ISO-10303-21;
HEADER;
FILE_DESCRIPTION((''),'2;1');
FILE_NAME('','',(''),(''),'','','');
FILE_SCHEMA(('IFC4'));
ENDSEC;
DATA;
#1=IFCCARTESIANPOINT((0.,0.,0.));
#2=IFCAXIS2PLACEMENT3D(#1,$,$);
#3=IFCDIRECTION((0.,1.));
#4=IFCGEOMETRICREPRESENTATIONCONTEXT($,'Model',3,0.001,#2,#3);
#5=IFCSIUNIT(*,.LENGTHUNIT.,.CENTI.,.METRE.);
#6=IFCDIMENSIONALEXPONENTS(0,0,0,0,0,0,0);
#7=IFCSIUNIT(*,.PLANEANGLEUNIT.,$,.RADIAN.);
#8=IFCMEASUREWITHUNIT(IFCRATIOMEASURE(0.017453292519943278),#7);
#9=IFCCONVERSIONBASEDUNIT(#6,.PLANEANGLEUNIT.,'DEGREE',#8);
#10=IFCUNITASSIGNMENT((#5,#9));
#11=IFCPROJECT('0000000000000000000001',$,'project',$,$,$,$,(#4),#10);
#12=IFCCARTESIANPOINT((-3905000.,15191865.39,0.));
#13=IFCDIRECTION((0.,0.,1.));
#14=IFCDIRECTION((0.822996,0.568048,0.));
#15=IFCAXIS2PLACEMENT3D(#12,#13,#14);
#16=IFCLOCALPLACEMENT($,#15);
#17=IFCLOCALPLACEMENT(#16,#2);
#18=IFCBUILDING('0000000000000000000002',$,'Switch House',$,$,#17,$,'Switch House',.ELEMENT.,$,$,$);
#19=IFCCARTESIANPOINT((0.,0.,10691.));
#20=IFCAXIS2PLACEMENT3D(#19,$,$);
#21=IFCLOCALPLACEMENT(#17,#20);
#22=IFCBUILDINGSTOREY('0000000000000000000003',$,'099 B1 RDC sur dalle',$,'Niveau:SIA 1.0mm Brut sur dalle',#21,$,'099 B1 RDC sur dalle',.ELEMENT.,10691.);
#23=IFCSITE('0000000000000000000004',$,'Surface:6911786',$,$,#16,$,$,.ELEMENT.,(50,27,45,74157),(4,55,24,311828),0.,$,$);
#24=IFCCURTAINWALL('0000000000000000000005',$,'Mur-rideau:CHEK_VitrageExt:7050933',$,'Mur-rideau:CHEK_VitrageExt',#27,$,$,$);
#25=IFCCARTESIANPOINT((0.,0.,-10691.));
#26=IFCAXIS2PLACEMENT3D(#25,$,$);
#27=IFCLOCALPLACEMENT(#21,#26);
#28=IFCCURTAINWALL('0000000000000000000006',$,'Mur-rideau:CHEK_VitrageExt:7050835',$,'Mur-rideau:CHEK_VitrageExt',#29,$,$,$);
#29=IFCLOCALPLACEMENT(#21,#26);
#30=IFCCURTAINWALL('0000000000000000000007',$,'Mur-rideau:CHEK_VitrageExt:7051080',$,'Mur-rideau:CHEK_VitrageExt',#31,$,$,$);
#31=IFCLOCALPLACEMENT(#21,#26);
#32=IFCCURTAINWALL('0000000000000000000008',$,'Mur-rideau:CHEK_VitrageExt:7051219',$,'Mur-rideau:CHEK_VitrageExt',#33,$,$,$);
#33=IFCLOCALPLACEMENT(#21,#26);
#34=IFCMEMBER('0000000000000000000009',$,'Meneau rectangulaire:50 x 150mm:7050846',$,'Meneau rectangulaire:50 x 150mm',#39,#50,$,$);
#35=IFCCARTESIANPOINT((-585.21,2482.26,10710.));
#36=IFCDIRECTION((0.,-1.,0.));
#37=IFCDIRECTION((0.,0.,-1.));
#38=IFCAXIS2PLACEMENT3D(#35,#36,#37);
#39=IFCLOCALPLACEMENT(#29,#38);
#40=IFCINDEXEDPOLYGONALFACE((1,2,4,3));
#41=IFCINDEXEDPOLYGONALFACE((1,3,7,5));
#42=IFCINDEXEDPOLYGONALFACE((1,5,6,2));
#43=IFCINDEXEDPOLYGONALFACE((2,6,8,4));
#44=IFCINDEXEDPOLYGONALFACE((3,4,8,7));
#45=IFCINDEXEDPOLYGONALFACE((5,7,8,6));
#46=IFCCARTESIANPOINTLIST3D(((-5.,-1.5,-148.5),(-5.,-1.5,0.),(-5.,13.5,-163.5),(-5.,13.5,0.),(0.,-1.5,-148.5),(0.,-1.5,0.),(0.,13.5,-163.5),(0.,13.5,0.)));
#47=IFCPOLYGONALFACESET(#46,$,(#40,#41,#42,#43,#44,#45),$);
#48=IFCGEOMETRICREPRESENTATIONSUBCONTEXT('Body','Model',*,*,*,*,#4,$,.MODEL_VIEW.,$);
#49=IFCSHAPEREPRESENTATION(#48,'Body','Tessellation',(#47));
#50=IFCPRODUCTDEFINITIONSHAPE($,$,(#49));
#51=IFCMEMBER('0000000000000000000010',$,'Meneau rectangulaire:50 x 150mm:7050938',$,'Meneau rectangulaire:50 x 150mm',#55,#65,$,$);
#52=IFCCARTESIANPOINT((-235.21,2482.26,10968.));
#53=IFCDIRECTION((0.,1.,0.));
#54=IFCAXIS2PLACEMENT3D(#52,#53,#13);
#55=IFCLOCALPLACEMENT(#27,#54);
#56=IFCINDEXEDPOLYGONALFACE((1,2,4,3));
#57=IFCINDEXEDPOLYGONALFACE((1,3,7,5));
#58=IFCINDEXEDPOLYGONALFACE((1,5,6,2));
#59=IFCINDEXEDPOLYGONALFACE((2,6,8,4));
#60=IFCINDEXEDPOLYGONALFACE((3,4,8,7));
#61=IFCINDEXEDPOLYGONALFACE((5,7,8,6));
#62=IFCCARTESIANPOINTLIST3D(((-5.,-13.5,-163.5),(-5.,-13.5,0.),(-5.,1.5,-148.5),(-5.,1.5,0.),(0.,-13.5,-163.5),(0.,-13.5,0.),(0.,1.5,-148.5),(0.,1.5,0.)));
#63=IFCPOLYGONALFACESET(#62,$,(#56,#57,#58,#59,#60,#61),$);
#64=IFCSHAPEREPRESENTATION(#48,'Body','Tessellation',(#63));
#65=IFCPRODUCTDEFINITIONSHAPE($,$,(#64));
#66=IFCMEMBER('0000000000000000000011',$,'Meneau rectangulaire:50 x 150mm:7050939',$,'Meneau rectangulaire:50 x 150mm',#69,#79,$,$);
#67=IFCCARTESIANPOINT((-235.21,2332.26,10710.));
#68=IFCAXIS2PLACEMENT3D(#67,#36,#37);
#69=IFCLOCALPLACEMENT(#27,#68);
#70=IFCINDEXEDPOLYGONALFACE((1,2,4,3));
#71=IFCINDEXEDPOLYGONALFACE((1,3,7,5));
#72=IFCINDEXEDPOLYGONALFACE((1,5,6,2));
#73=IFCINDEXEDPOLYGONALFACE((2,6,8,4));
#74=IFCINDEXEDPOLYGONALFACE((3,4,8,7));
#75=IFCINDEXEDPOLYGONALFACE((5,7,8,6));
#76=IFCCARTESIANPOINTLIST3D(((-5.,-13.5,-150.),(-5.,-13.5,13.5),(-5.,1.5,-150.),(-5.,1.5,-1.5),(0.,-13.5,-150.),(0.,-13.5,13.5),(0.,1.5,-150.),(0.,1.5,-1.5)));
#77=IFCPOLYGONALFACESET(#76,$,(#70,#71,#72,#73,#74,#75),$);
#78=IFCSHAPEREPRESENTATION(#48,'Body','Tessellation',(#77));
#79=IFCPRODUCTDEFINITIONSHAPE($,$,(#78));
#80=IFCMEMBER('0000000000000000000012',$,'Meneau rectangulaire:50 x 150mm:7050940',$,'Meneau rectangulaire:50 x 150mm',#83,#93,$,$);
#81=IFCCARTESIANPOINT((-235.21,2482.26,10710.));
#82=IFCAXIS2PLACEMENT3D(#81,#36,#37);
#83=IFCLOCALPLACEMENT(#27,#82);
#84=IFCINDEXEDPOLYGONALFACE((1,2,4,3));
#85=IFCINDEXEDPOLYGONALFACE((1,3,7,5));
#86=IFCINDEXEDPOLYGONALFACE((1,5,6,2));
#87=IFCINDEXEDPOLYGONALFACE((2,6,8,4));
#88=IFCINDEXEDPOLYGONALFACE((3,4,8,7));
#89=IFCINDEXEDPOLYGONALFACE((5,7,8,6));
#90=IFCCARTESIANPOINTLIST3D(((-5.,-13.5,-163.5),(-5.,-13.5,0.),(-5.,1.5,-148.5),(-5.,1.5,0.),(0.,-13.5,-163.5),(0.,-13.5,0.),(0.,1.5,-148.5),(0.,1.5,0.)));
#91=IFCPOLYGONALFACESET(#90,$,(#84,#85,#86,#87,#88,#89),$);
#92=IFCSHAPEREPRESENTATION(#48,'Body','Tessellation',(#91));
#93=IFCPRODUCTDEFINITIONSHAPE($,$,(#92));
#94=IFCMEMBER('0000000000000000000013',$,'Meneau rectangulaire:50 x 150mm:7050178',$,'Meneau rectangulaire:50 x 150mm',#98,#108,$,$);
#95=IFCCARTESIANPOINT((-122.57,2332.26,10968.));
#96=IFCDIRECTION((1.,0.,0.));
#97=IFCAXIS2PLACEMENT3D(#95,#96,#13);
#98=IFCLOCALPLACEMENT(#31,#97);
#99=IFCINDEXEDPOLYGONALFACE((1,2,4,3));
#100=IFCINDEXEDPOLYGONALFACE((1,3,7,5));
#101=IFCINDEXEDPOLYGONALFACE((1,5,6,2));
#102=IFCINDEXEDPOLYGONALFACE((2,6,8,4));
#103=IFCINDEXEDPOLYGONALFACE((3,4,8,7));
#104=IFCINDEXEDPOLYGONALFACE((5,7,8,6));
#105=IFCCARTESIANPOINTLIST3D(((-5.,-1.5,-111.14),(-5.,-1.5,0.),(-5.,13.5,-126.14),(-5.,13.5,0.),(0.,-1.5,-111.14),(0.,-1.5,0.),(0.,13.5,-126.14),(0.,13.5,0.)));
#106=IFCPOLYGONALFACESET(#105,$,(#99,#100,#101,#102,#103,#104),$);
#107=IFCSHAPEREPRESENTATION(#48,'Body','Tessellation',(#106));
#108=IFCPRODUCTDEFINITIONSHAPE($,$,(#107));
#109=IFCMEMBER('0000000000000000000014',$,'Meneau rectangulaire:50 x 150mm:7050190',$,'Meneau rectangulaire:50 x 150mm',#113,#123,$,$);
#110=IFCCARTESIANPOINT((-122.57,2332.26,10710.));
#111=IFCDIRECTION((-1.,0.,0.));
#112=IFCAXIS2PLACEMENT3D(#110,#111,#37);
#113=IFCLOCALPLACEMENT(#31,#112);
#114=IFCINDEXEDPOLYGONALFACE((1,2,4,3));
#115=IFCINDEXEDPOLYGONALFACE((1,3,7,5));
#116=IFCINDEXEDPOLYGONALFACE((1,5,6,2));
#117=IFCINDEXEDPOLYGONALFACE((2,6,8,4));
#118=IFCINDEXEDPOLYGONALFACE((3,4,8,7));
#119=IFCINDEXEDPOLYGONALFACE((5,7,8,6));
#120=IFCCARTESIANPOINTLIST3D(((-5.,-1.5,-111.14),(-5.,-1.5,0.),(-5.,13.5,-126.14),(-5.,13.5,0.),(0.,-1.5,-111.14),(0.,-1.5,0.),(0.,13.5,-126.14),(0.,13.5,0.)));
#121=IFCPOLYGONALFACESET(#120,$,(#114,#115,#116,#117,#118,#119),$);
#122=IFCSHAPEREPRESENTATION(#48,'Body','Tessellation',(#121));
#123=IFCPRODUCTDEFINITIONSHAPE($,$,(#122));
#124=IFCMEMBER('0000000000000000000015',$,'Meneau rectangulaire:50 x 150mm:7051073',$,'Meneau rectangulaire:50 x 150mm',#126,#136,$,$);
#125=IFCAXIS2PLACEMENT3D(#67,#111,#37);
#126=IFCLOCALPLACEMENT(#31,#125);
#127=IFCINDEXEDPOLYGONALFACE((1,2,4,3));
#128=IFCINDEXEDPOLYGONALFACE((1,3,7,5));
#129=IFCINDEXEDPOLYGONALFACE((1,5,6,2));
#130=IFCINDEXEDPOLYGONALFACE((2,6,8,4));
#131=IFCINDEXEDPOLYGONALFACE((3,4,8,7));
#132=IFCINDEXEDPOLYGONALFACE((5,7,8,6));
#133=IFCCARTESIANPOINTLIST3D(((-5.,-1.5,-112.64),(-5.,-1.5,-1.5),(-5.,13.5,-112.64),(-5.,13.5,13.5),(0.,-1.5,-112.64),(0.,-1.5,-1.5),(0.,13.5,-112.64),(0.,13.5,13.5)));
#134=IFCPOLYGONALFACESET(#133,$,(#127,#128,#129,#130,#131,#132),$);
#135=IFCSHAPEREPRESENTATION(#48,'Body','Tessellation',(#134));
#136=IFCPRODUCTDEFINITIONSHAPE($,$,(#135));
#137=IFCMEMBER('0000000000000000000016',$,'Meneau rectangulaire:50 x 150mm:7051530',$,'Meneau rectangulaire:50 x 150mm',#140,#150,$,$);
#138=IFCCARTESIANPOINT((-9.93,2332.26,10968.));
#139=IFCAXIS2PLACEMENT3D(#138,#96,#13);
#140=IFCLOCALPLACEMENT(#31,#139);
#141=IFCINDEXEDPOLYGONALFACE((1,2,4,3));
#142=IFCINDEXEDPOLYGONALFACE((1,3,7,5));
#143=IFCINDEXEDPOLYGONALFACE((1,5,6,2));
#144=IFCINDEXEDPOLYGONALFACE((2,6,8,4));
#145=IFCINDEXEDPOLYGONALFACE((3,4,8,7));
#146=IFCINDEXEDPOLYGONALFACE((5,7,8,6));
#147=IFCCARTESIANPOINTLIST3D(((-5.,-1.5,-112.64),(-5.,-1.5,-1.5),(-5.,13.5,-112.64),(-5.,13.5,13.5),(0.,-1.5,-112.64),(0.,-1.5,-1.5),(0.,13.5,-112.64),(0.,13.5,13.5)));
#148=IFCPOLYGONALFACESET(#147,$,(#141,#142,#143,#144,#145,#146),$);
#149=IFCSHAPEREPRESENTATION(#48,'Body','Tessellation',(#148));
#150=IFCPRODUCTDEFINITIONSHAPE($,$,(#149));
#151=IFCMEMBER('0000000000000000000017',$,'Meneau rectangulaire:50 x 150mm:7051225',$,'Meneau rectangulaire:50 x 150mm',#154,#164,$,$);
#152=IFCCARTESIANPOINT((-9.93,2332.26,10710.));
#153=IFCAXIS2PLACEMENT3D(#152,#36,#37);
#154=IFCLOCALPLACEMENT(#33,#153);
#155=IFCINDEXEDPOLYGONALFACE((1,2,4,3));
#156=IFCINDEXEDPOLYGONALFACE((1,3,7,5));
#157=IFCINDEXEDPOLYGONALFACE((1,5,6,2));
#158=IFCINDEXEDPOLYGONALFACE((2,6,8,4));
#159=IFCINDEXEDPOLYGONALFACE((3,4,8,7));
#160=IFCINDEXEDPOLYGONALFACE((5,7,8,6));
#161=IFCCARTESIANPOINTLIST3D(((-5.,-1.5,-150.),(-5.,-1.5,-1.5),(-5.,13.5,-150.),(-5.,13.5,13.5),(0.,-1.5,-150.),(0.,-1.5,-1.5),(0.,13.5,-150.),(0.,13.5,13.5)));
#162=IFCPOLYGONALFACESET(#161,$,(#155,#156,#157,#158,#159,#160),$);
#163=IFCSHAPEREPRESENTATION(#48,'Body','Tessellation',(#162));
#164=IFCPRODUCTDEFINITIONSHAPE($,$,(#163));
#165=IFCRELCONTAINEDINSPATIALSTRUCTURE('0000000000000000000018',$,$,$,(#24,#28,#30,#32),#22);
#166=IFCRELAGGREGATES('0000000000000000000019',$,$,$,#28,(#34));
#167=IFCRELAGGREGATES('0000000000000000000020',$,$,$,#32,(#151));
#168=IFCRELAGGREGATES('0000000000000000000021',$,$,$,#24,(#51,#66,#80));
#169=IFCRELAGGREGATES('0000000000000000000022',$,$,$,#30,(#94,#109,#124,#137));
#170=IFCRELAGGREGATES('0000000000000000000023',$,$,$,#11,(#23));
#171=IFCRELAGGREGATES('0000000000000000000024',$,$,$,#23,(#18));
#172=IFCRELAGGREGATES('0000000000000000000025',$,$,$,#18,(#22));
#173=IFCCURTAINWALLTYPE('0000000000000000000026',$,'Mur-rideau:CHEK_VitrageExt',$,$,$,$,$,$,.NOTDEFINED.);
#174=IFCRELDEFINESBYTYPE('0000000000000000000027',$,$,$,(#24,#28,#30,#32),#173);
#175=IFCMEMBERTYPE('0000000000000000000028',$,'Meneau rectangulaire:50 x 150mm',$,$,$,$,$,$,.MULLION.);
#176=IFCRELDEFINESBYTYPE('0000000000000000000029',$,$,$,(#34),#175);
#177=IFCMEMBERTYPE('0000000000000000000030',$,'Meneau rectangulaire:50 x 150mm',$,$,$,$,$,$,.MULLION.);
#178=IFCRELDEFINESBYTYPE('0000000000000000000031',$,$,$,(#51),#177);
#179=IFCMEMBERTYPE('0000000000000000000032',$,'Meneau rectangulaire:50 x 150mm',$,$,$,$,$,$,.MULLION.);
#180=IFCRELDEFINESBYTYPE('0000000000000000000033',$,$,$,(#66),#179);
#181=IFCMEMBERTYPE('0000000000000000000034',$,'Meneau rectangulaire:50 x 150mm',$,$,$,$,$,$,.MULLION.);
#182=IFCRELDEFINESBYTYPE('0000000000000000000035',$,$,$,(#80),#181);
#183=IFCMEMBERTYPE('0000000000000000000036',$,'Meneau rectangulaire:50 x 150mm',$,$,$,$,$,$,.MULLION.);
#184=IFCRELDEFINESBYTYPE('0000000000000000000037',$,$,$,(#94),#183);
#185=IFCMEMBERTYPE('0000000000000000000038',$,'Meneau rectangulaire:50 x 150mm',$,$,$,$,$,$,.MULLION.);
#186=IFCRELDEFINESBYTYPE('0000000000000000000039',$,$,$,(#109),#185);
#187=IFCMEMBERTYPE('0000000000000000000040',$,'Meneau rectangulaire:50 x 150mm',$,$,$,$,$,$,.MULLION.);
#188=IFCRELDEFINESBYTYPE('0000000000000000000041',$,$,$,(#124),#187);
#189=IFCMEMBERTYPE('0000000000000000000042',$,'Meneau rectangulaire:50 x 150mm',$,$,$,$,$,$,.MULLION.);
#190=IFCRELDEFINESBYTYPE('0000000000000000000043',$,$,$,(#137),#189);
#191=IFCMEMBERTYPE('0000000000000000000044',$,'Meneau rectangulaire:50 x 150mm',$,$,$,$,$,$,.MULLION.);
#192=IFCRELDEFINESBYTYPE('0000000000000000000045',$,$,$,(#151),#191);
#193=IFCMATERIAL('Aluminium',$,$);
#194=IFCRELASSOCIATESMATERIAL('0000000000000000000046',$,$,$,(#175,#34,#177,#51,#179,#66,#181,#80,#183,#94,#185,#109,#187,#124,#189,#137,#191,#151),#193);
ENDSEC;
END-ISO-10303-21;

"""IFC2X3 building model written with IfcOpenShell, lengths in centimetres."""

from ifc_helpers import new_model, entity, si_unit, converted_unit, direction, frame, origin, origin_2d_with_axis, place, context, subcontext, project, spatial, rectangle, extrude, clip, halfspace, source, transform, mapped, material, type_object, type_shapes, element, aggregate, save


model = new_model("IFC2X3")

# Units and contexts
model_context = context("Model", 3, precision=0.001, world=origin(), true_north=direction((0.0, 1.0)))
body_context = subcontext(model_context, "Body", "Model", "MODEL_VIEW")
ifc_project = project(units=[si_unit("LENGTHUNIT", "METRE", prefix="CENTI"), converted_unit("PLANEANGLEUNIT", "DEGREE", entity("IfcRatioMeasure", 0.017453292519943278), si_unit("PLANEANGLEUNIT", "RADIAN"), dimensions=[0, 0, 0, 0, 0, 0, 0])], contexts=[model_context])

# Site, building, storey
site_placement = place(None, frame((-3905000.0, 15191865.39, 0.0), z_axis=(0.0, 0.0, 1.0), x_axis=(0.822996, 0.568048, 0.0)))
site = spatial("IfcSite", under=ifc_project, at=site_placement, Name="Surface:6911786", CompositionType="ELEMENT", RefLatitude=(50, 27, 45, 74157), RefLongitude=(4, 55, 24, 311828), RefElevation=0.0)
building_placement = place(site_placement, origin())
building = spatial("IfcBuilding", under=site, at=building_placement, Name="Switch House", LongName="Switch House", CompositionType="ELEMENT")
storey_placement = place(building_placement, frame((0.0, 0.0, 10691.0)))
storey = spatial("IfcBuildingStorey", under=building, at=storey_placement, Name="099 B1 RDC sur dalle", ObjectType="Niveau:SIA 1.0mm Brut sur dalle", LongName="099 B1 RDC sur dalle", CompositionType="ELEMENT", Elevation=10691.0)

# Curtain wall
curtain_wall_type = type_object("IfcCurtainWallType", Name="Mur-rideau:CHEK_VitrageExt", PredefinedType="NOTDEFINED")
curtain_wall_1_placement = place(storey_placement, frame((0.0, 0.0, -10691.0)))
curtain_wall_1 = element("IfcCurtainWall", 1, at=curtain_wall_1_placement, inside=storey, type_object=curtain_wall_type, Name="Mur-rideau:CHEK_VitrageExt:7050933", ObjectType="Mur-rideau:CHEK_VitrageExt")
ifc_material_1 = material(Name="Aluminium")

# Curtain walls
curtain_wall_2_placement = place(storey_placement, frame((0.0, 0.0, -10691.0)))
curtain_wall_2 = element("IfcCurtainWall", 2, at=curtain_wall_2_placement, inside=storey, type_object=curtain_wall_type, Name="Mur-rideau:CHEK_VitrageExt:7050835", ObjectType="Mur-rideau:CHEK_VitrageExt")
curtain_wall_3_placement = place(storey_placement, frame((0.0, 0.0, -10691.0)))
curtain_wall_3 = element("IfcCurtainWall", 3, at=curtain_wall_3_placement, inside=storey, type_object=curtain_wall_type, Name="Mur-rideau:CHEK_VitrageExt:7051080", ObjectType="Mur-rideau:CHEK_VitrageExt")
curtain_wall_4_placement = place(storey_placement, frame((0.0, 0.0, -10691.0)))
curtain_wall_4 = element("IfcCurtainWall", 4, at=curtain_wall_4_placement, inside=storey, type_object=curtain_wall_type, Name="Mur-rideau:CHEK_VitrageExt:7051219", ObjectType="Mur-rideau:CHEK_VitrageExt")

# Members
member_type_1 = type_object("IfcMemberType", Name="Meneau rectangulaire:50 x 150mm", PredefinedType="MULLION", material=ifc_material_1)
shared_shape_1 = source(origin(), body_context, "Body", "SweptSolid", [
    clip(extrude(rectangle(XDim=15.0, YDim=5.0, at=origin_2d_with_axis()), frame((-2.5, 6.0, -163.5), z_axis=(0.0, 0.0, 1.0), x_axis=(0.0, -1.0, 0.0)), (0.0, 0.0, 1.0), 163.5), halfspace(frame((30.48, 0.0, -150.0), z_axis=(0.0, -0.707107, -0.707107), x_axis=(0.0, -0.707107, 0.707107)), False)),
])
type_shapes(member_type_1, [shared_shape_1])
member_1_placement = place(curtain_wall_2_placement, frame((-585.21, 2482.26, 10710.0), z_axis=(0.0, -1.0, 0.0), x_axis=(0.0, 0.0, -1.0)))
member_1 = element("IfcMember", 5, at=member_1_placement, type_object=member_type_1, material=ifc_material_1, Name="Meneau rectangulaire:50 x 150mm:7050846", ObjectType="Meneau rectangulaire:50 x 150mm", context=body_context, shape_type="MappedRepresentation", body=[
    mapped(shared_shape_1, transform((0.0, 0.0, 0.0), scale=1.0)),
])
member_type_2 = type_object("IfcMemberType", Name="Meneau rectangulaire:50 x 150mm", PredefinedType="MULLION", material=ifc_material_1)
shared_shape_2 = source(origin(), body_context, "Body", "SweptSolid", [
    clip(extrude(rectangle(XDim=15.0, YDim=5.0, at=origin_2d_with_axis()), frame((-2.5, -6.0, -163.5), z_axis=(0.0, 0.0, 1.0), x_axis=(0.0, -1.0, 0.0)), (0.0, 0.0, 1.0), 163.5), halfspace(frame((-30.48, 0.0, -150.0), z_axis=(0.0, 0.707107, -0.707107), x_axis=(0.0, 0.707107, 0.707107)), False)),
])
type_shapes(member_type_2, [shared_shape_2])
member_2_placement = place(curtain_wall_1_placement, frame((-235.21, 2482.26, 10968.0), z_axis=(0.0, 1.0, 0.0), x_axis=(0.0, 0.0, 1.0)))
member_2 = element("IfcMember", 6, at=member_2_placement, type_object=member_type_2, material=ifc_material_1, Name="Meneau rectangulaire:50 x 150mm:7050938", ObjectType="Meneau rectangulaire:50 x 150mm", context=body_context, shape_type="MappedRepresentation", body=[
    mapped(shared_shape_2, transform((0.0, 0.0, 0.0), scale=1.0)),
])
member_type_3 = type_object("IfcMemberType", Name="Meneau rectangulaire:50 x 150mm", PredefinedType="MULLION", material=ifc_material_1)
shared_shape_3 = source(origin(), body_context, "Body", "SweptSolid", [
    clip(extrude(rectangle(XDim=15.0, YDim=5.0, at=origin_2d_with_axis()), frame((-2.5, -6.0, -150.0), z_axis=(0.0, 0.0, 1.0), x_axis=(0.0, -1.0, 0.0)), (0.0, 0.0, 1.0), 163.5), halfspace(frame((-30.48, 0.0, 0.0), z_axis=(0.0, 0.707107, 0.707107), x_axis=(0.0, 0.707107, -0.707107)), False)),
])
type_shapes(member_type_3, [shared_shape_3])
member_3_placement = place(curtain_wall_1_placement, frame((-235.21, 2332.26, 10710.0), z_axis=(0.0, -1.0, 0.0), x_axis=(0.0, 0.0, -1.0)))
member_3 = element("IfcMember", 7, at=member_3_placement, type_object=member_type_3, material=ifc_material_1, Name="Meneau rectangulaire:50 x 150mm:7050939", ObjectType="Meneau rectangulaire:50 x 150mm", context=body_context, shape_type="MappedRepresentation", body=[
    mapped(shared_shape_3, transform((0.0, 0.0, 0.0), scale=1.0)),
])
member_type_4 = type_object("IfcMemberType", Name="Meneau rectangulaire:50 x 150mm", PredefinedType="MULLION", material=ifc_material_1)
shared_shape_4 = source(origin(), body_context, "Body", "SweptSolid", [
    clip(extrude(rectangle(XDim=15.0, YDim=5.0, at=origin_2d_with_axis()), frame((-2.5, -6.0, -163.5), z_axis=(0.0, 0.0, 1.0), x_axis=(0.0, -1.0, 0.0)), (0.0, 0.0, 1.0), 163.5), halfspace(frame((-30.48, 0.0, -150.0), z_axis=(0.0, 0.707107, -0.707107), x_axis=(0.0, 0.707107, 0.707107)), False)),
])
type_shapes(member_type_4, [shared_shape_4])
member_4_placement = place(curtain_wall_1_placement, frame((-235.21, 2482.26, 10710.0), z_axis=(0.0, -1.0, 0.0), x_axis=(0.0, 0.0, -1.0)))
member_4 = element("IfcMember", 8, at=member_4_placement, type_object=member_type_4, material=ifc_material_1, Name="Meneau rectangulaire:50 x 150mm:7050940", ObjectType="Meneau rectangulaire:50 x 150mm", context=body_context, shape_type="MappedRepresentation", body=[
    mapped(shared_shape_4, transform((0.0, 0.0, 0.0), scale=1.0)),
])
member_type_5 = type_object("IfcMemberType", Name="Meneau rectangulaire:50 x 150mm", PredefinedType="MULLION", material=ifc_material_1)
shared_shape_5 = source(origin(), body_context, "Body", "SweptSolid", [
    clip(extrude(rectangle(XDim=15.0, YDim=5.0, at=origin_2d_with_axis()), frame((-2.5, 6.0, -126.14), z_axis=(0.0, 0.0, 1.0), x_axis=(0.0, -1.0, 0.0)), (0.0, 0.0, 1.0), 126.14), halfspace(frame((30.48, 0.0, -112.64), z_axis=(0.0, -0.707107, -0.707107), x_axis=(0.0, -0.707107, 0.707107)), False)),
])
type_shapes(member_type_5, [shared_shape_5])
member_5_placement = place(curtain_wall_3_placement, frame((-122.57, 2332.26, 10968.0), z_axis=(1.0, 0.0, 0.0), x_axis=(0.0, 0.0, 1.0)))
member_5 = element("IfcMember", 9, at=member_5_placement, type_object=member_type_5, material=ifc_material_1, Name="Meneau rectangulaire:50 x 150mm:7050178", ObjectType="Meneau rectangulaire:50 x 150mm", context=body_context, shape_type="MappedRepresentation", body=[
    mapped(shared_shape_5, transform((0.0, 0.0, 0.0), scale=1.0)),
])
member_type_6 = type_object("IfcMemberType", Name="Meneau rectangulaire:50 x 150mm", PredefinedType="MULLION", material=ifc_material_1)
shared_shape_6 = source(origin(), body_context, "Body", "SweptSolid", [
    clip(extrude(rectangle(XDim=15.0, YDim=5.0, at=origin_2d_with_axis()), frame((-2.5, 6.0, -126.14), z_axis=(0.0, 0.0, 1.0), x_axis=(0.0, -1.0, 0.0)), (0.0, 0.0, 1.0), 126.14), halfspace(frame((30.48, 0.0, -112.64), z_axis=(0.0, -0.707107, -0.707107), x_axis=(0.0, -0.707107, 0.707107)), False)),
])
type_shapes(member_type_6, [shared_shape_6])
member_6_placement = place(curtain_wall_3_placement, frame((-122.57, 2332.26, 10710.0), z_axis=(-1.0, 0.0, 0.0), x_axis=(0.0, 0.0, -1.0)))
member_6 = element("IfcMember", 10, at=member_6_placement, type_object=member_type_6, material=ifc_material_1, Name="Meneau rectangulaire:50 x 150mm:7050190", ObjectType="Meneau rectangulaire:50 x 150mm", context=body_context, shape_type="MappedRepresentation", body=[
    mapped(shared_shape_6, transform((0.0, 0.0, 0.0), scale=1.0)),
])
member_type_7 = type_object("IfcMemberType", Name="Meneau rectangulaire:50 x 150mm", PredefinedType="MULLION", material=ifc_material_1)
shared_shape_7 = source(origin(), body_context, "Body", "SweptSolid", [
    clip(extrude(rectangle(XDim=15.0, YDim=5.0, at=origin_2d_with_axis()), frame((-2.5, 6.0, -112.64), z_axis=(0.0, 0.0, 1.0), x_axis=(0.0, -1.0, 0.0)), (0.0, 0.0, 1.0), 126.14), halfspace(frame((30.48, 0.0, 0.0), z_axis=(0.0, -0.707107, 0.707107), x_axis=(0.0, -0.707107, -0.707107)), False)),
])
type_shapes(member_type_7, [shared_shape_7])
member_7_placement = place(curtain_wall_3_placement, frame((-235.21, 2332.26, 10710.0), z_axis=(-1.0, 0.0, 0.0), x_axis=(0.0, 0.0, -1.0)))
member_7 = element("IfcMember", 11, at=member_7_placement, type_object=member_type_7, material=ifc_material_1, Name="Meneau rectangulaire:50 x 150mm:7051073", ObjectType="Meneau rectangulaire:50 x 150mm", context=body_context, shape_type="MappedRepresentation", body=[
    mapped(shared_shape_7, transform((0.0, 0.0, 0.0), scale=1.0)),
])
member_type_8 = type_object("IfcMemberType", Name="Meneau rectangulaire:50 x 150mm", PredefinedType="MULLION", material=ifc_material_1)
shared_shape_8 = source(origin(), body_context, "Body", "SweptSolid", [
    clip(extrude(rectangle(XDim=15.0, YDim=5.0, at=origin_2d_with_axis()), frame((-2.5, 6.0, -112.64), z_axis=(0.0, 0.0, 1.0), x_axis=(0.0, -1.0, 0.0)), (0.0, 0.0, 1.0), 126.14), halfspace(frame((30.48, 0.0, 0.0), z_axis=(0.0, -0.707107, 0.707107), x_axis=(0.0, -0.707107, -0.707107)), False)),
])
type_shapes(member_type_8, [shared_shape_8])
member_8_placement = place(curtain_wall_3_placement, frame((-9.93, 2332.26, 10968.0), z_axis=(1.0, 0.0, 0.0), x_axis=(0.0, 0.0, 1.0)))
member_8 = element("IfcMember", 12, at=member_8_placement, type_object=member_type_8, material=ifc_material_1, Name="Meneau rectangulaire:50 x 150mm:7051530", ObjectType="Meneau rectangulaire:50 x 150mm", context=body_context, shape_type="MappedRepresentation", body=[
    mapped(shared_shape_8, transform((0.0, 0.0, 0.0), scale=1.0)),
])
member_type_9 = type_object("IfcMemberType", Name="Meneau rectangulaire:50 x 150mm", PredefinedType="MULLION", material=ifc_material_1)
shared_shape_9 = source(origin(), body_context, "Body", "SweptSolid", [
    clip(extrude(rectangle(XDim=15.0, YDim=5.0, at=origin_2d_with_axis()), frame((-2.5, 6.0, -150.0), z_axis=(0.0, 0.0, 1.0), x_axis=(0.0, -1.0, 0.0)), (0.0, 0.0, 1.0), 163.5), halfspace(frame((30.48, 0.0, 0.0), z_axis=(0.0, -0.707107, 0.707107), x_axis=(0.0, -0.707107, -0.707107)), False)),
])
type_shapes(member_type_9, [shared_shape_9])
member_9_placement = place(curtain_wall_4_placement, frame((-9.93, 2332.26, 10710.0), z_axis=(0.0, -1.0, 0.0), x_axis=(0.0, 0.0, -1.0)))
member_9 = element("IfcMember", 13, at=member_9_placement, type_object=member_type_9, material=ifc_material_1, Name="Meneau rectangulaire:50 x 150mm:7051225", ObjectType="Meneau rectangulaire:50 x 150mm", context=body_context, shape_type="MappedRepresentation", body=[
    mapped(shared_shape_9, transform((0.0, 0.0, 0.0), scale=1.0)),
])

aggregate(curtain_wall_2, [member_1])
aggregate(curtain_wall_4, [member_9])
aggregate(curtain_wall_1, [member_2, member_3, member_4])
aggregate(curtain_wall_3, [member_5, member_6, member_7, member_8])

save(model, "model.ifc")
